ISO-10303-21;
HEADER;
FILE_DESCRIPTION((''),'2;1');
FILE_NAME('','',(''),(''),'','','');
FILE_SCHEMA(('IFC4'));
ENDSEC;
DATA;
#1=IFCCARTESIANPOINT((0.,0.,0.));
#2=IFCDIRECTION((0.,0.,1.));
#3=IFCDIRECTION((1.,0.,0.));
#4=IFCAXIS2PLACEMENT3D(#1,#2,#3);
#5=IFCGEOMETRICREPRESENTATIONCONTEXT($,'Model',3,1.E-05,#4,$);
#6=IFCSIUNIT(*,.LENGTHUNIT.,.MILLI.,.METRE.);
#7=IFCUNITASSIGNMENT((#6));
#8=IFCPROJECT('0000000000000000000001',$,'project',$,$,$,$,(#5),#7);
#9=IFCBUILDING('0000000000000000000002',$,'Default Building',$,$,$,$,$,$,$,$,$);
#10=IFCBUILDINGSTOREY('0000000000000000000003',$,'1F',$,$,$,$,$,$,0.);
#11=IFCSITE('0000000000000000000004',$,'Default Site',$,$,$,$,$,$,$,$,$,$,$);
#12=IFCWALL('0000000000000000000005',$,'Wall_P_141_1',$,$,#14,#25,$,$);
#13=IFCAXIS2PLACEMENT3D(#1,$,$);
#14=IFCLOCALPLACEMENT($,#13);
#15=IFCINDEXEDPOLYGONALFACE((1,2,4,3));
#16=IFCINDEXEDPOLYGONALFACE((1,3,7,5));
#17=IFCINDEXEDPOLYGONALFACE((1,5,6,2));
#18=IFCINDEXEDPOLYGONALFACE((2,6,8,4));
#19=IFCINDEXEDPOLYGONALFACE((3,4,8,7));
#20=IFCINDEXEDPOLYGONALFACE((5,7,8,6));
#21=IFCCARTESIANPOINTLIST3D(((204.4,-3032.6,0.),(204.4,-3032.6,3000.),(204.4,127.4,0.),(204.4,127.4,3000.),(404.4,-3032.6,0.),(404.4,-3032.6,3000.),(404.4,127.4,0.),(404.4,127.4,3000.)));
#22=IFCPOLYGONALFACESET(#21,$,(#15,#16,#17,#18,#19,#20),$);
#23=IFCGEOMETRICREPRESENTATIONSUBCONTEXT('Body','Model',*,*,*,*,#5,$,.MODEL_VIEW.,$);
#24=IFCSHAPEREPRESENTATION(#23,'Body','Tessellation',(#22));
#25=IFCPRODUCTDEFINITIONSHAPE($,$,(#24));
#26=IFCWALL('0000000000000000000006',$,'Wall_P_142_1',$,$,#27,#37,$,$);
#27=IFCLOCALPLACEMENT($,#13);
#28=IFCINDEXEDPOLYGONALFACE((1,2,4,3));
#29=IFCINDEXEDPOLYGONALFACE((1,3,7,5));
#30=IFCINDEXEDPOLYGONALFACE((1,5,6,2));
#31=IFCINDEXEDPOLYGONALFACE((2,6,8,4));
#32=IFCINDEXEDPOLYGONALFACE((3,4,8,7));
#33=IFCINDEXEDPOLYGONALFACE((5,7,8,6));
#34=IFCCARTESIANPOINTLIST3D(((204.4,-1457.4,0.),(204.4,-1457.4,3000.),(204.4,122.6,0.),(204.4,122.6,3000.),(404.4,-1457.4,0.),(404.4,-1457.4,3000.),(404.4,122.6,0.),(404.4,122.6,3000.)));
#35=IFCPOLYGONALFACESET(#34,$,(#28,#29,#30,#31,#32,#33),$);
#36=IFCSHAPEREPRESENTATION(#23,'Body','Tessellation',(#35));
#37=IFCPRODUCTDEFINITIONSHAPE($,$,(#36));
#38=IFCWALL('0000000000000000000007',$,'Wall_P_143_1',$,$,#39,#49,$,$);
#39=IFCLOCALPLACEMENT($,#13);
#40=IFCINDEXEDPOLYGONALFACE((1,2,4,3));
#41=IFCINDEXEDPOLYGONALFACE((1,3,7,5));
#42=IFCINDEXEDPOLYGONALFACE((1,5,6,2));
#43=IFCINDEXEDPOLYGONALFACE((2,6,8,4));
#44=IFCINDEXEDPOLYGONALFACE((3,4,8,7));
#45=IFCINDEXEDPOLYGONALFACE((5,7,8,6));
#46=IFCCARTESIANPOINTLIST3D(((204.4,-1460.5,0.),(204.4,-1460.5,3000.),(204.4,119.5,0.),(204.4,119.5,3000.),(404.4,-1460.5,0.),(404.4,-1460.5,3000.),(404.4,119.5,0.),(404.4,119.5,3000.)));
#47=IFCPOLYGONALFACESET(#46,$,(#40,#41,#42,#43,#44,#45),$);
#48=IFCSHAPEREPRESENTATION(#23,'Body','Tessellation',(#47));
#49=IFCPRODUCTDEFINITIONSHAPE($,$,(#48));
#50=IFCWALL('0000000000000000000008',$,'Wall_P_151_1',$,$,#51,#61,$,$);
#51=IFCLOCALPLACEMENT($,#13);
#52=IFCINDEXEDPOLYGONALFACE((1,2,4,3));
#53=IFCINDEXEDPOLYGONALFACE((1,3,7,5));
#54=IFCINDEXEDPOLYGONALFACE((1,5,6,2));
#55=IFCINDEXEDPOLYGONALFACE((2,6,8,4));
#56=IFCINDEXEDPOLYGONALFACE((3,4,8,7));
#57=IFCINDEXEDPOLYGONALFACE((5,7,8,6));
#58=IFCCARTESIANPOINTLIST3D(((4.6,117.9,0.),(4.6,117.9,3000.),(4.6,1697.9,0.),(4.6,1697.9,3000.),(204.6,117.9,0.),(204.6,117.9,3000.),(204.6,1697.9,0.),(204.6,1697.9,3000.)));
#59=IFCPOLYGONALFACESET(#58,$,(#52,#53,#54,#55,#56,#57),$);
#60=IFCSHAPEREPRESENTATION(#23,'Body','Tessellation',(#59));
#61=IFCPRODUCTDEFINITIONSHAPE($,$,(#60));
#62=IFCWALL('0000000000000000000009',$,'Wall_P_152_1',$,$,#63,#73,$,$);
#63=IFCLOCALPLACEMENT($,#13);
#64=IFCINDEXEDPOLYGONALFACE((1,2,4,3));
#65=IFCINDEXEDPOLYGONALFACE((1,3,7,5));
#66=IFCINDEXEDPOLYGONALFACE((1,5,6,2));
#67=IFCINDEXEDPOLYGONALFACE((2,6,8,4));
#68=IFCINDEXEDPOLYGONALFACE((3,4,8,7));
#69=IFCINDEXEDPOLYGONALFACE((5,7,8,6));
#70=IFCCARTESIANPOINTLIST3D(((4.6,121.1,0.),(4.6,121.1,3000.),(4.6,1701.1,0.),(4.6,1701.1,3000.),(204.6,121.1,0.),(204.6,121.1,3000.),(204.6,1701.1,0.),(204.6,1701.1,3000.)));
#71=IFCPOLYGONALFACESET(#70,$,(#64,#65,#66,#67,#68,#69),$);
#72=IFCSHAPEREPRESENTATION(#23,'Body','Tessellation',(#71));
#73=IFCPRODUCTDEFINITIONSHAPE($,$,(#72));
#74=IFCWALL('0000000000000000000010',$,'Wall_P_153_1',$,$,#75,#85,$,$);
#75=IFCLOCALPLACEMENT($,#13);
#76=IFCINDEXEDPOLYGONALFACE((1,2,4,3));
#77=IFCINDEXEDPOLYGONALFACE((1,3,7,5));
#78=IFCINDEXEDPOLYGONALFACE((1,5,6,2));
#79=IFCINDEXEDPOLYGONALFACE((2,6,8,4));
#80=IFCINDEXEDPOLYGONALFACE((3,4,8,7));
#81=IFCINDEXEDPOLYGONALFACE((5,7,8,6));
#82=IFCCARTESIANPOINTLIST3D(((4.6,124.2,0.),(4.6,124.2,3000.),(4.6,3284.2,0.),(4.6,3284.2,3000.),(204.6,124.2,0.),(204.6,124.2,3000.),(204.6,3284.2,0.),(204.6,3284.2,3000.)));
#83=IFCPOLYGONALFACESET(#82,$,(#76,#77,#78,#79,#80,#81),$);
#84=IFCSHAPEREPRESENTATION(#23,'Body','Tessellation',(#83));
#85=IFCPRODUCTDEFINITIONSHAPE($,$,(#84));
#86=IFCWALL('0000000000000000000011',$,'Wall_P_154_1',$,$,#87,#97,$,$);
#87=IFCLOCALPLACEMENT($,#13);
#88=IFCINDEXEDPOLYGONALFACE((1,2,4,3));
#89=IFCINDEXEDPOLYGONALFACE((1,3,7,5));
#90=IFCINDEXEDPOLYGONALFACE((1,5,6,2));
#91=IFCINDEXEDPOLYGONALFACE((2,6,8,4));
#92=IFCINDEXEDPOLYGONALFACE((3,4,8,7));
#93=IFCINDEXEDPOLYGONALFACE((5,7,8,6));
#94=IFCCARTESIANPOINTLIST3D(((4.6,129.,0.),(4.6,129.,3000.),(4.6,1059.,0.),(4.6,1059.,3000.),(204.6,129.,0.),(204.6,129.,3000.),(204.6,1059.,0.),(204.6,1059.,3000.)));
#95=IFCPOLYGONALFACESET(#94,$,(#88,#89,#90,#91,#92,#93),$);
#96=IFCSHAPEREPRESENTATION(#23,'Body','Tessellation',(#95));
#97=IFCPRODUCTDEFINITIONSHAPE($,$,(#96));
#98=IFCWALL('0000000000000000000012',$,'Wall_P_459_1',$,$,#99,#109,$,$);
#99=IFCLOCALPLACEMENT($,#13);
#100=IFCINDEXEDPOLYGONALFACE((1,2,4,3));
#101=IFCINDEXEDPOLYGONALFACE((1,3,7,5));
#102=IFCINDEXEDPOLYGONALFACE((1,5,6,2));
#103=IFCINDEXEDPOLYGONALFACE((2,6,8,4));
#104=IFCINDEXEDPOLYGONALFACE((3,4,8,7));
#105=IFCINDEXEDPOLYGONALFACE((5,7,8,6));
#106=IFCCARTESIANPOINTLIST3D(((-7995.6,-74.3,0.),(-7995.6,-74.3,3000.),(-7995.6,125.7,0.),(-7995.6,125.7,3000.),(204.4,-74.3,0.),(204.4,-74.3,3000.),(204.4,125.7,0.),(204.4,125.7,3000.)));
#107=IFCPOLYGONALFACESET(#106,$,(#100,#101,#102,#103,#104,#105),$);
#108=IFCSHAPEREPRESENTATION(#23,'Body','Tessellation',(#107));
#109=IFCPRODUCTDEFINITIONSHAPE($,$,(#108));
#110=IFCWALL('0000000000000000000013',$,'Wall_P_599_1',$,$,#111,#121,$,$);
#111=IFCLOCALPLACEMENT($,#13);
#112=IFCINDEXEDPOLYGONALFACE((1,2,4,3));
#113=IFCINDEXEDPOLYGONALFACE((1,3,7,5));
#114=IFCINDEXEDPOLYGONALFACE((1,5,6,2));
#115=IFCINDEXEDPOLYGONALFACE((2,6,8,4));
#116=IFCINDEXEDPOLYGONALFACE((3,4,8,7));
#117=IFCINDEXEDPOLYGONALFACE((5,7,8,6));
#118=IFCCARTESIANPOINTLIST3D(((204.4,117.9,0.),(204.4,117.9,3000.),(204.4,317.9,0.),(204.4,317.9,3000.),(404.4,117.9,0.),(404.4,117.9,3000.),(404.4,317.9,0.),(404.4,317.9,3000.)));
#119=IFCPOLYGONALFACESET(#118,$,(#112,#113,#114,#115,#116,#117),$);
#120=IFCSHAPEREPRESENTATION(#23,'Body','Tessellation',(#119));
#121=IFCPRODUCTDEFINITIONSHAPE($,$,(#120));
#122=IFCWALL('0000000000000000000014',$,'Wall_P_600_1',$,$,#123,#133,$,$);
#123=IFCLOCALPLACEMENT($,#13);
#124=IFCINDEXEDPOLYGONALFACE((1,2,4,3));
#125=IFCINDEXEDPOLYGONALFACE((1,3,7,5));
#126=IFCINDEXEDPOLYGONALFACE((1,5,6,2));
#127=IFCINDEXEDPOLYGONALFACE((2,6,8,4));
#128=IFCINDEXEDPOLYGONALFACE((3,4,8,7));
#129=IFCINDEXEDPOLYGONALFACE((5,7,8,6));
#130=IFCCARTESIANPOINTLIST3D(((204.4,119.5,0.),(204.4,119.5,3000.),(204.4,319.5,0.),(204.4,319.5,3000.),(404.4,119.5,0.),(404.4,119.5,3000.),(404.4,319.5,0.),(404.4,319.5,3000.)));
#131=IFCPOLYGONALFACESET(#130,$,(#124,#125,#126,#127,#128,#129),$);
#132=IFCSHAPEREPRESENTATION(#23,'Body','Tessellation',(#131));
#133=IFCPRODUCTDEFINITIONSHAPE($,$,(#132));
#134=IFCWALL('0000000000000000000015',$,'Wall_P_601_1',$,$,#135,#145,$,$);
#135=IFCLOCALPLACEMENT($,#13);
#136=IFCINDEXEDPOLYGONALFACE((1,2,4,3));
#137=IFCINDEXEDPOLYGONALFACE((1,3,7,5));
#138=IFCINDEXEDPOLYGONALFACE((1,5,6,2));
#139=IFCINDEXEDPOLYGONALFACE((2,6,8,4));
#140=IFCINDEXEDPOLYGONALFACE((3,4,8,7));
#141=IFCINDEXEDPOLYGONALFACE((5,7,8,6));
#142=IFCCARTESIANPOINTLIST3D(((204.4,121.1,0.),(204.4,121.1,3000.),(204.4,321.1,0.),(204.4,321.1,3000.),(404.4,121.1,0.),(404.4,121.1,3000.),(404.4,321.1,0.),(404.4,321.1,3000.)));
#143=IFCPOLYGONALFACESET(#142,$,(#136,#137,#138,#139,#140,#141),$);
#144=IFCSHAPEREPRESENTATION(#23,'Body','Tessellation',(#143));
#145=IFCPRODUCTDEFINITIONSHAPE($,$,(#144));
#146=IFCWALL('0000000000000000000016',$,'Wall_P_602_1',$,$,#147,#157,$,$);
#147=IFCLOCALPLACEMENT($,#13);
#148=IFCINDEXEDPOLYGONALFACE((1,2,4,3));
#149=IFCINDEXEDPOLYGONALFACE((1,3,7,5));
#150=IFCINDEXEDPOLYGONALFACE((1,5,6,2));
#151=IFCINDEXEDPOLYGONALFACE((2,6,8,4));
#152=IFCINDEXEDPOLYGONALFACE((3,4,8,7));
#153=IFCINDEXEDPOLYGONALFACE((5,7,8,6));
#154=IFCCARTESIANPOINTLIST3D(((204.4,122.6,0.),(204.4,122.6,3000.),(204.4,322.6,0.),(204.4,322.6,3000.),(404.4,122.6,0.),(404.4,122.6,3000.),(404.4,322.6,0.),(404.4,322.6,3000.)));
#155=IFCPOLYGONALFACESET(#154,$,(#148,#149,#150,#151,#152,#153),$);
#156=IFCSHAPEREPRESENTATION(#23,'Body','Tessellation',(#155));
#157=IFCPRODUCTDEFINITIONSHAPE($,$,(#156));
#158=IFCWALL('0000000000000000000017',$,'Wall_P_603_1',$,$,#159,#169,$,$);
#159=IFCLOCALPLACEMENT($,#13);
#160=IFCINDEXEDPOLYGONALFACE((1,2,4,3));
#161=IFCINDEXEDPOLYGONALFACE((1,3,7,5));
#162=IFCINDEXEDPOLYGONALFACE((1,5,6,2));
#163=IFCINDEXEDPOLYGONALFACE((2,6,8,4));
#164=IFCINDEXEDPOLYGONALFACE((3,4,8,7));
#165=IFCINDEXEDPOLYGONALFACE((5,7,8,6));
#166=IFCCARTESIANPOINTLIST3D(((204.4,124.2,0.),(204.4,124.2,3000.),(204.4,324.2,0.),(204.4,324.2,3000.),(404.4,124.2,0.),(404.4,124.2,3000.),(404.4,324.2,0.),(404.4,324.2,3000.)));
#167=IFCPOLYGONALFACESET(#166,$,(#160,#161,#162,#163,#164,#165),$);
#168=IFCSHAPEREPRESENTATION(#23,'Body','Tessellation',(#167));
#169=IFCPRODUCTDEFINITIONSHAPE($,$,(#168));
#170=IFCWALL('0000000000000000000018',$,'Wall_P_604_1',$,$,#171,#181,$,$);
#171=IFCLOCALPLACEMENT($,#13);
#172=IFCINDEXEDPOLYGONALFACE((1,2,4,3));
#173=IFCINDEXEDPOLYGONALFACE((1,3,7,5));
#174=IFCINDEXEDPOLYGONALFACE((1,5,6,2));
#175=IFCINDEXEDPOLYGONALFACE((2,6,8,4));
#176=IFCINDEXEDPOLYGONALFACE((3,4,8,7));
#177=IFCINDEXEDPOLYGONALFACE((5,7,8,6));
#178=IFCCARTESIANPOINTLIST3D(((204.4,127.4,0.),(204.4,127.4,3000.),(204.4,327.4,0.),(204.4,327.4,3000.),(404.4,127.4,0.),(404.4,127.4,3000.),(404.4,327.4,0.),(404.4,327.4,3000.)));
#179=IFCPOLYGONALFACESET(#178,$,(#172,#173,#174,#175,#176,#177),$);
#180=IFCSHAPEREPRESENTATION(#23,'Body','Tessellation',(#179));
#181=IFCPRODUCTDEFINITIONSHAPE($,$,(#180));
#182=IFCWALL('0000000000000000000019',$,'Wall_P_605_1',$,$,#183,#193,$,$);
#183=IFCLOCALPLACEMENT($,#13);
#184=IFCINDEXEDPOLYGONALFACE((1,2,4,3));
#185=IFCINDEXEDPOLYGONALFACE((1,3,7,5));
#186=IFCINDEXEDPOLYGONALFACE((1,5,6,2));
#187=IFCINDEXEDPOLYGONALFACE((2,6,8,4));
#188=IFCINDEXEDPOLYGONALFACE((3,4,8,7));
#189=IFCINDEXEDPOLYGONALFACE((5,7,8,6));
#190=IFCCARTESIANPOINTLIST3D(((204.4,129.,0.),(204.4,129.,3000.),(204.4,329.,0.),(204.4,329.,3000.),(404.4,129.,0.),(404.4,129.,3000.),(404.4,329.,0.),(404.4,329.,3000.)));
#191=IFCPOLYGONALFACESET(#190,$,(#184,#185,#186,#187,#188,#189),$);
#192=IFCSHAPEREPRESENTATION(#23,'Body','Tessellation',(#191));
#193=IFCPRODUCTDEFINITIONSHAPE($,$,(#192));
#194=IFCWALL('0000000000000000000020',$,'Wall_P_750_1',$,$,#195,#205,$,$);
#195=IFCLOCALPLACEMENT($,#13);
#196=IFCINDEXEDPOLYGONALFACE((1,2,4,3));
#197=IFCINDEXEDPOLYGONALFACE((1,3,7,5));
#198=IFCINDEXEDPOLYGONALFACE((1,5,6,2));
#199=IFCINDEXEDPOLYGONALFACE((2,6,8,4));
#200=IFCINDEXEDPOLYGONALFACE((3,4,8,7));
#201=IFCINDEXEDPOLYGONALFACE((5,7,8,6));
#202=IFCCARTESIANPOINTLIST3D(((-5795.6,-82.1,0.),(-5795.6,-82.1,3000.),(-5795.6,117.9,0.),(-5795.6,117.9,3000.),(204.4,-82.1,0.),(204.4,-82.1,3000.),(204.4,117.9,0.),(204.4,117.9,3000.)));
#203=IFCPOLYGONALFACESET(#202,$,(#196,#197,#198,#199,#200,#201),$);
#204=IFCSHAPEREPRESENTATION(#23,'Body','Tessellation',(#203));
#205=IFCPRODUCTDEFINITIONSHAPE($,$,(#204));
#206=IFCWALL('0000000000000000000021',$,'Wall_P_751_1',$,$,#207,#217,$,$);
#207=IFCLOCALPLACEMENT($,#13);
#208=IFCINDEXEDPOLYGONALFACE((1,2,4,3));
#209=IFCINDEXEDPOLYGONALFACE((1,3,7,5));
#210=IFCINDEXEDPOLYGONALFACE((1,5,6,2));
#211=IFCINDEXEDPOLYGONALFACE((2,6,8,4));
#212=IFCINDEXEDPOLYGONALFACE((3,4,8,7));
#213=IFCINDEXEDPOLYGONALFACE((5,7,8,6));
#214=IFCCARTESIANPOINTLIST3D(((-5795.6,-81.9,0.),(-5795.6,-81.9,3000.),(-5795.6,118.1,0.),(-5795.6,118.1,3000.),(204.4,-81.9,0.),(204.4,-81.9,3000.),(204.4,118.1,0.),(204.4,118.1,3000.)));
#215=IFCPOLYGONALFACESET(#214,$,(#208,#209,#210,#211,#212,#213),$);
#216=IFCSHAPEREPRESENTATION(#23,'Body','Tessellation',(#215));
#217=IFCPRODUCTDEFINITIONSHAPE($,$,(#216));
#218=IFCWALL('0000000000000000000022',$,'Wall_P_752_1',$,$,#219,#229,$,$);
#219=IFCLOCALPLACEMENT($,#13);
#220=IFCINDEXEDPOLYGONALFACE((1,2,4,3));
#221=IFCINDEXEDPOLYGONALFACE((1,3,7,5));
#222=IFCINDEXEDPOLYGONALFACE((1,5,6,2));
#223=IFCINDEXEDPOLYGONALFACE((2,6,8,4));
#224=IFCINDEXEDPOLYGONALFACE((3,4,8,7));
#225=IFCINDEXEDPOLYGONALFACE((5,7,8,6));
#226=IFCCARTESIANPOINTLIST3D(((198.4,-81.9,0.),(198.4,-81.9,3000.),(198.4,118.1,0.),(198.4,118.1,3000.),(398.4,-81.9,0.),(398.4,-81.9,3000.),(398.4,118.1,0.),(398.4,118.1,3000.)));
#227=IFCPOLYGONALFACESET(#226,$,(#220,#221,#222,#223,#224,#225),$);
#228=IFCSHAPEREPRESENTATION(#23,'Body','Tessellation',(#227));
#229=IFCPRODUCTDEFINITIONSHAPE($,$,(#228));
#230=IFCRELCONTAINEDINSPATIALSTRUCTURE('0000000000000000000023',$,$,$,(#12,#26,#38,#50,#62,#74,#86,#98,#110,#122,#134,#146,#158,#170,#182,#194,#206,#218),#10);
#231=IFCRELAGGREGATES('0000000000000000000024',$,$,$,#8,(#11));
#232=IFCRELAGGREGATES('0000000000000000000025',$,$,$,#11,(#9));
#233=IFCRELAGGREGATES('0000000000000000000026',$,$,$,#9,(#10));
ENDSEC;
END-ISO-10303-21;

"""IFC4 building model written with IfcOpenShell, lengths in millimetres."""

from ifc_helpers import new_model, si_unit, frame, origin_with_axes, place, context, subcontext, project, spatial, indexed_curve, outline, extrude, element, save


model = new_model("IFC4")

# Units and contexts
model_context = context("Model", 3, precision=1e-05, world=origin_with_axes())
body_context = subcontext(model_context, "Body", "Model", "MODEL_VIEW")
ifc_project = project(units=[si_unit("LENGTHUNIT", "METRE", prefix="MILLI")], contexts=[model_context])

# Site, building, storey
site = spatial("IfcSite", under=ifc_project, Name="Default Site")
building = spatial("IfcBuilding", under=site, Name="Default Building")
storey = spatial("IfcBuildingStorey", under=building, Name="1F", Elevation=0.0)

# Walls
wall_1_placement = place(None, frame((204.4, 127.4, 0.0), z_axis=(0.0, 0.0, 1.0), x_axis=(0.0, -1.0, 0.0)))
element("IfcWall", 1, at=wall_1_placement, inside=storey, Name="Wall_P_141_1", context=body_context, shape_type="SweptSolid", body=[
    extrude(outline(indexed_curve([(0.0, 0.0), (0.0, 200.0), (3160.0, 200.0), (3160.0, 0.0), (0.0, 0.0)], self_intersect=False)), origin_with_axes(), (0.0, 0.0, 1.0), 3000.0),
])
wall_2_placement = place(None, frame((204.4, 122.6, 0.0), z_axis=(0.0, 0.0, 1.0), x_axis=(0.0, -1.0, 0.0)))
element("IfcWall", 2, at=wall_2_placement, inside=storey, Name="Wall_P_142_1", context=body_context, shape_type="SweptSolid", body=[
    extrude(outline(indexed_curve([(0.0, 0.0), (0.0, 200.0), (1580.0, 200.0), (1580.0, 0.0), (0.0, 0.0)], self_intersect=False)), origin_with_axes(), (0.0, 0.0, 1.0), 3000.0),
])
for number, where, z_axis, x_axis, name in (
    (3, (204.4, 119.5, 0.0), (0.0, 0.0, 1.0), (0.0, -1.0, 0.0), "Wall_P_143_1"),
    (4, (204.6, 117.9, 0.0), (0.0, 0.0, 1.0), (0.0, 1.0, 0.0), "Wall_P_151_1"),
):
    element("IfcWall", number, at=place(None, frame(where, z_axis=z_axis, x_axis=x_axis)), inside=storey, Name=name, context=body_context, shape_type="SweptSolid", body=[
        extrude(outline(indexed_curve([(0.0, 0.0), (0.0, 200.0), (1580.0, 200.0), (1580.0, 0.0), (0.0, 0.0)], self_intersect=False)), origin_with_axes(), (0.0, 0.0, 1.0), 3000.0),
    ])
wall_3_placement = place(None, frame((204.6, 121.1, 0.0), z_axis=(0.0, 0.0, 1.0), x_axis=(0.0, 1.0, 0.0)))
element("IfcWall", 5, at=wall_3_placement, inside=storey, Name="Wall_P_152_1", context=body_context, shape_type="SweptSolid", body=[
    extrude(outline(indexed_curve([(0.0, 0.0), (0.0, 200.0), (1580.0, 200.0), (1580.0, 0.0), (0.0, 0.0)], self_intersect=False)), origin_with_axes(), (0.0, 0.0, 1.0), 3000.0),
])
wall_4_placement = place(None, frame((204.6, 124.2, 0.0), z_axis=(0.0, 0.0, 1.0), x_axis=(0.0, 1.0, 0.0)))
element("IfcWall", 6, at=wall_4_placement, inside=storey, Name="Wall_P_153_1", context=body_context, shape_type="SweptSolid", body=[
    extrude(outline(indexed_curve([(0.0, 0.0), (0.0, 200.0), (3160.0, 200.0), (3160.0, 0.0), (0.0, 0.0)], self_intersect=False)), origin_with_axes(), (0.0, 0.0, 1.0), 3000.0),
])
wall_5_placement = place(None, frame((204.6, 129.0, 0.0), z_axis=(0.0, 0.0, 1.0), x_axis=(0.0, 1.0, 0.0)))
element("IfcWall", 7, at=wall_5_placement, inside=storey, Name="Wall_P_154_1", context=body_context, shape_type="SweptSolid", body=[
    extrude(outline(indexed_curve([(0.0, 0.0), (0.0, 200.0), (930.0, 200.0), (930.0, 0.0), (0.0, 0.0)], self_intersect=False)), origin_with_axes(), (0.0, 0.0, 1.0), 3000.0),
])
wall_6_placement = place(None, frame((204.4, 125.7, 0.0), z_axis=(0.0, 0.0, 1.0), x_axis=(-1.0, 0.0, 0.0)))
element("IfcWall", 8, at=wall_6_placement, inside=storey, Name="Wall_P_459_1", context=body_context, shape_type="SweptSolid", body=[
    extrude(outline(indexed_curve([(0.0, 0.0), (0.0, 200.0), (8200.0, 200.0), (8200.0, 0.0), (0.0, 0.0)], self_intersect=False)), origin_with_axes(), (0.0, 0.0, 1.0), 3000.0),
])
for number, where, z_axis, x_axis, name in (
    (9, (204.4, 117.9, 0.0), (0.0, 0.0, 1.0), (1.0, 0.0, 0.0), "Wall_P_599_1"),
    (10, (204.4, 119.5, 0.0), (0.0, 0.0, 1.0), (1.0, 0.0, 0.0), "Wall_P_600_1"),
    (11, (204.4, 121.1, 0.0), (0.0, 0.0, 1.0), (1.0, 0.0, 0.0), "Wall_P_601_1"),
    (12, (204.4, 122.6, 0.0), (0.0, 0.0, 1.0), (1.0, 0.0, 0.0), "Wall_P_602_1"),
    (13, (204.4, 124.2, 0.0), (0.0, 0.0, 1.0), (1.0, 0.0, 0.0), "Wall_P_603_1"),
    (14, (204.4, 127.4, 0.0), (0.0, 0.0, 1.0), (1.0, 0.0, 0.0), "Wall_P_604_1"),
    (15, (204.4, 129.0, 0.0), (0.0, 0.0, 1.0), (1.0, 0.0, 0.0), "Wall_P_605_1"),
):
    element("IfcWall", number, at=place(None, frame(where, z_axis=z_axis, x_axis=x_axis)), inside=storey, Name=name, context=body_context, shape_type="SweptSolid", body=[
        extrude(outline(indexed_curve([(0.0, 0.0), (0.0, 200.0), (200.0, 200.0), (200.0, 0.0), (0.0, 0.0)], self_intersect=False)), origin_with_axes(), (0.0, 0.0, 1.0), 3000.0),
    ])
for number, where, z_axis, x_axis, name in (
    (16, (204.4, 117.9, 0.0), (0.0, 0.0, 1.0), (-1.0, 0.0, 0.0), "Wall_P_750_1"),
    (17, (204.4, 118.1, 0.0), (0.0, 0.0, 1.0), (-1.0, 0.0, 0.0), "Wall_P_751_1"),
):
    element("IfcWall", number, at=place(None, frame(where, z_axis=z_axis, x_axis=x_axis)), inside=storey, Name=name, context=body_context, shape_type="SweptSolid", body=[
        extrude(outline(indexed_curve([(0.0, 0.0), (0.0, 200.0), (6000.0, 200.0), (6000.0, 0.0), (0.0, 0.0)], self_intersect=False)), origin_with_axes(), (0.0, 0.0, 1.0), 3000.0),
    ])
wall_7_placement = place(None, frame((198.4, 118.1, 0.0), z_axis=(0.0, 0.0, 1.0), x_axis=(0.0, -1.0, 0.0)))
element("IfcWall", 18, at=wall_7_placement, inside=storey, Name="Wall_P_752_1", context=body_context, shape_type="SweptSolid", body=[
    extrude(outline(indexed_curve([(0.0, 0.0), (0.0, 200.0), (200.0, 200.0), (200.0, 0.0), (0.0, 0.0)], self_intersect=False)), origin_with_axes(), (0.0, 0.0, 1.0), 3000.0),
])

save(model, "model.ifc")
